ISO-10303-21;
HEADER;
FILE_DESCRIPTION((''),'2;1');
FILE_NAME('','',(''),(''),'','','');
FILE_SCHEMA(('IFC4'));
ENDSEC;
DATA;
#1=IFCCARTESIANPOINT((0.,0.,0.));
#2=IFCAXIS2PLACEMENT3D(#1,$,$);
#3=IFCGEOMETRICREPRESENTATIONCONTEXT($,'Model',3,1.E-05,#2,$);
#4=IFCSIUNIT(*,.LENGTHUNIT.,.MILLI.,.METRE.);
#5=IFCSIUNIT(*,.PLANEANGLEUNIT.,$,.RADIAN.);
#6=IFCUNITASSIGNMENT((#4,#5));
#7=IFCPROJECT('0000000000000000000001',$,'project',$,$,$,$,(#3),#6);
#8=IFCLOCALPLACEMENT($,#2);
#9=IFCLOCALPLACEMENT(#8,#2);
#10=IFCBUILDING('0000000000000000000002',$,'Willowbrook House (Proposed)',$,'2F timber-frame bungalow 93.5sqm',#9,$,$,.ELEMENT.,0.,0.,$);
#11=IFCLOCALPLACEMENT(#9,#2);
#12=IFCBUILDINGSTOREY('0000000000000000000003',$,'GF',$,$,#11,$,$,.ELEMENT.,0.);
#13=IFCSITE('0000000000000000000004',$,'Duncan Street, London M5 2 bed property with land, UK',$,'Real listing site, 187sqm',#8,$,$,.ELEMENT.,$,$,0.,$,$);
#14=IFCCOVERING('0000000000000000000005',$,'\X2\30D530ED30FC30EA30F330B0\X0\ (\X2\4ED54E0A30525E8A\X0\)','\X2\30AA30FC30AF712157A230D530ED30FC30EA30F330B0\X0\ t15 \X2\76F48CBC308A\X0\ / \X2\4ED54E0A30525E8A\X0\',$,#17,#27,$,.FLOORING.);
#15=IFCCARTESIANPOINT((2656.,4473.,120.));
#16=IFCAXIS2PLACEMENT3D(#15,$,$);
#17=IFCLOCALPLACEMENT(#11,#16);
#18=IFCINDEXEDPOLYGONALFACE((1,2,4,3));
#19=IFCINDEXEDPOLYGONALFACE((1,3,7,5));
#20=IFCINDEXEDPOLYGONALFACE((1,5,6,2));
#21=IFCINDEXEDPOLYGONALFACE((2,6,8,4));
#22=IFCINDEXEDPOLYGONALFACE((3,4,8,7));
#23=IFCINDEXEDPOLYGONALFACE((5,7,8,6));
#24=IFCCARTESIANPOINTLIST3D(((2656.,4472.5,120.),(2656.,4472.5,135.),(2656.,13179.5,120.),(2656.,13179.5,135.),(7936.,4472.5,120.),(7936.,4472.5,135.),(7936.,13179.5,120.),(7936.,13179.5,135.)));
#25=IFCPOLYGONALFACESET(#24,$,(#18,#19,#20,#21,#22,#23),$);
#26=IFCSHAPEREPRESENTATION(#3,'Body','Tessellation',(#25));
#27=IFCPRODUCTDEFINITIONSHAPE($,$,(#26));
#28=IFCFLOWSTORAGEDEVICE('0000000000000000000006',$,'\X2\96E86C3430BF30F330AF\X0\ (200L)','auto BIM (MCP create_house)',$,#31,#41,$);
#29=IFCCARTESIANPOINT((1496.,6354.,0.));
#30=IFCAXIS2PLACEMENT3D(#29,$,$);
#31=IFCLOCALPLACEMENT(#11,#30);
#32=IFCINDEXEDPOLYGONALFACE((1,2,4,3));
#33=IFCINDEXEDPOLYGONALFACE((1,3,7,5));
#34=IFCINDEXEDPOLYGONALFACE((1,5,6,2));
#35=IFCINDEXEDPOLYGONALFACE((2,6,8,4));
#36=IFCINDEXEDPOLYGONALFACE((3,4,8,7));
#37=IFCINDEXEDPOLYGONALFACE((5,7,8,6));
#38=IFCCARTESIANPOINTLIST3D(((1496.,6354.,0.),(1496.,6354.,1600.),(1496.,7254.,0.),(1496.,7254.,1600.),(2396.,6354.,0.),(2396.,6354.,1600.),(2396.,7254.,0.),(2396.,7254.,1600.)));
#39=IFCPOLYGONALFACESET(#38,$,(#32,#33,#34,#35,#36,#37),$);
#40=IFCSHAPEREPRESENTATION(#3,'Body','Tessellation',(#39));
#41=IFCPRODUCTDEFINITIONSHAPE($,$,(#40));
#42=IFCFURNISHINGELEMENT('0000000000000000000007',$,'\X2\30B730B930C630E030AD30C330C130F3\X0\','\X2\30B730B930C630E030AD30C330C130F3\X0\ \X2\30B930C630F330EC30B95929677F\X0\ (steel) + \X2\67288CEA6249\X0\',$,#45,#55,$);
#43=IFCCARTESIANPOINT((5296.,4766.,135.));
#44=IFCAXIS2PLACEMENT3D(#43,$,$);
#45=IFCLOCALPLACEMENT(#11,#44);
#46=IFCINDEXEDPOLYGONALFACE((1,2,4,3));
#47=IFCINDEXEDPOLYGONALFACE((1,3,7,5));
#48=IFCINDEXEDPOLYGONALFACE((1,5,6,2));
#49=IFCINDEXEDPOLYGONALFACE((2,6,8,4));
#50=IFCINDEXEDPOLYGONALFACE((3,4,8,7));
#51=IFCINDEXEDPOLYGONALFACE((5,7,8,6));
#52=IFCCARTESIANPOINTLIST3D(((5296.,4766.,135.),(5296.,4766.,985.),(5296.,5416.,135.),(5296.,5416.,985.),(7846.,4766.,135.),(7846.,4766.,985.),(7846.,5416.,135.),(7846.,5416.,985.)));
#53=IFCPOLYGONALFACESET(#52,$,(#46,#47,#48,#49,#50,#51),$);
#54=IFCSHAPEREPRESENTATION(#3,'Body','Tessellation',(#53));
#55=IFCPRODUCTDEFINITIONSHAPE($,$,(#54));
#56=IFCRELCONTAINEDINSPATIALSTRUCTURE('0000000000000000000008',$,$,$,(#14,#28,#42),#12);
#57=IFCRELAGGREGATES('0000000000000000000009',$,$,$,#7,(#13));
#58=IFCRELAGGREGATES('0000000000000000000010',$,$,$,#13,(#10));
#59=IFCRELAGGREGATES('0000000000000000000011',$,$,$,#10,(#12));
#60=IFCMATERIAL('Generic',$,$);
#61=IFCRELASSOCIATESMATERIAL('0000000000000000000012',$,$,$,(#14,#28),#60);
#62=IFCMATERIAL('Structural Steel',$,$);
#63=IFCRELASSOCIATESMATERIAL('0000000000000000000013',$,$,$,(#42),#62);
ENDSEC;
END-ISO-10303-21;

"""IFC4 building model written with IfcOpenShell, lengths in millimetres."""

from ifc_helpers import new_model, si_unit, frame, frame_2d, origin, place, context, project, spatial, rectangle, extrude, material, element, save


model = new_model("IFC4")

# Units and contexts
model_context = context("Model", 3, precision=1e-05, world=origin())
ifc_project = project(units=[si_unit("LENGTHUNIT", "METRE", prefix="MILLI"), si_unit("PLANEANGLEUNIT", "RADIAN")], contexts=[model_context])

# Site, building, storey
site_placement = place(None, origin())
site = spatial("IfcSite", under=ifc_project, at=site_placement, Name="Duncan Street, London M5 2 bed property with land, UK", ObjectType="Real listing site, 187sqm", CompositionType="ELEMENT", RefElevation=0.0)
building_placement = place(site_placement, origin())
building = spatial("IfcBuilding", under=site, at=building_placement, Name="Willowbrook House (Proposed)", ObjectType="2F timber-frame bungalow 93.5sqm", CompositionType="ELEMENT", ElevationOfRefHeight=0.0, ElevationOfTerrain=0.0)
storey_placement = place(building_placement, origin())
storey = spatial("IfcBuildingStorey", under=building, at=storey_placement, Name="GF", CompositionType="ELEMENT", Elevation=0.0)

# Covering
ifc_material_1 = material(Name="Generic")
covering_placement = place(storey_placement, frame((2656.0, 4473.0, 120.0)))
element("IfcCovering", 1, at=covering_placement, inside=storey, material=ifc_material_1, Name="フローリング (仕上げ床)", Description="オーク無垢フローリング t15 直貼り / 仕上げ床", PredefinedType="FLOORING", context=model_context, shape_type="SweptSolid", body=[
    extrude(rectangle(XDim=5280.0, YDim=8707.0, at=frame_2d((2640.0, 4353.0))), frame((2656.0, 4473.0, 120.0)), (0.0, 0.0, 1.0), 15.0),
])

# Flow storage device
flow_storage_device_placement = place(storey_placement, frame((1496.0, 6354.0, 0.0)))
element("IfcFlowStorageDevice", 2, at=flow_storage_device_placement, inside=storey, material=ifc_material_1, Name="雨水タンク (200L)", Description="auto BIM (MCP create_house)", context=model_context, shape_type="SweptSolid", body=[
    extrude(rectangle(XDim=900.0, YDim=900.0, at=frame_2d((450.0, 450.0))), frame((1496.0, 6354.0, 0.0)), (0.0, 0.0, 1.0), 1600.0),
])

# Furnishing element
ifc_material_2 = material(Name="Structural Steel")
furnishing_placement = place(storey_placement, frame((5296.0, 4766.0, 135.0)))
element("IfcFurnishingElement", 3, at=furnishing_placement, inside=storey, material=ifc_material_2, Name="システムキッチン", Description="システムキッチン ステンレス天板 (steel) + 木質扉", context=model_context, shape_type="SweptSolid", body=[
    extrude(rectangle(XDim=2550.0, YDim=650.0, at=frame_2d((1275.0, 325.0))), frame((5296.0, 4766.0, 135.0)), (0.0, 0.0, 1.0), 850.0),
])

save(model, "model.ifc")
